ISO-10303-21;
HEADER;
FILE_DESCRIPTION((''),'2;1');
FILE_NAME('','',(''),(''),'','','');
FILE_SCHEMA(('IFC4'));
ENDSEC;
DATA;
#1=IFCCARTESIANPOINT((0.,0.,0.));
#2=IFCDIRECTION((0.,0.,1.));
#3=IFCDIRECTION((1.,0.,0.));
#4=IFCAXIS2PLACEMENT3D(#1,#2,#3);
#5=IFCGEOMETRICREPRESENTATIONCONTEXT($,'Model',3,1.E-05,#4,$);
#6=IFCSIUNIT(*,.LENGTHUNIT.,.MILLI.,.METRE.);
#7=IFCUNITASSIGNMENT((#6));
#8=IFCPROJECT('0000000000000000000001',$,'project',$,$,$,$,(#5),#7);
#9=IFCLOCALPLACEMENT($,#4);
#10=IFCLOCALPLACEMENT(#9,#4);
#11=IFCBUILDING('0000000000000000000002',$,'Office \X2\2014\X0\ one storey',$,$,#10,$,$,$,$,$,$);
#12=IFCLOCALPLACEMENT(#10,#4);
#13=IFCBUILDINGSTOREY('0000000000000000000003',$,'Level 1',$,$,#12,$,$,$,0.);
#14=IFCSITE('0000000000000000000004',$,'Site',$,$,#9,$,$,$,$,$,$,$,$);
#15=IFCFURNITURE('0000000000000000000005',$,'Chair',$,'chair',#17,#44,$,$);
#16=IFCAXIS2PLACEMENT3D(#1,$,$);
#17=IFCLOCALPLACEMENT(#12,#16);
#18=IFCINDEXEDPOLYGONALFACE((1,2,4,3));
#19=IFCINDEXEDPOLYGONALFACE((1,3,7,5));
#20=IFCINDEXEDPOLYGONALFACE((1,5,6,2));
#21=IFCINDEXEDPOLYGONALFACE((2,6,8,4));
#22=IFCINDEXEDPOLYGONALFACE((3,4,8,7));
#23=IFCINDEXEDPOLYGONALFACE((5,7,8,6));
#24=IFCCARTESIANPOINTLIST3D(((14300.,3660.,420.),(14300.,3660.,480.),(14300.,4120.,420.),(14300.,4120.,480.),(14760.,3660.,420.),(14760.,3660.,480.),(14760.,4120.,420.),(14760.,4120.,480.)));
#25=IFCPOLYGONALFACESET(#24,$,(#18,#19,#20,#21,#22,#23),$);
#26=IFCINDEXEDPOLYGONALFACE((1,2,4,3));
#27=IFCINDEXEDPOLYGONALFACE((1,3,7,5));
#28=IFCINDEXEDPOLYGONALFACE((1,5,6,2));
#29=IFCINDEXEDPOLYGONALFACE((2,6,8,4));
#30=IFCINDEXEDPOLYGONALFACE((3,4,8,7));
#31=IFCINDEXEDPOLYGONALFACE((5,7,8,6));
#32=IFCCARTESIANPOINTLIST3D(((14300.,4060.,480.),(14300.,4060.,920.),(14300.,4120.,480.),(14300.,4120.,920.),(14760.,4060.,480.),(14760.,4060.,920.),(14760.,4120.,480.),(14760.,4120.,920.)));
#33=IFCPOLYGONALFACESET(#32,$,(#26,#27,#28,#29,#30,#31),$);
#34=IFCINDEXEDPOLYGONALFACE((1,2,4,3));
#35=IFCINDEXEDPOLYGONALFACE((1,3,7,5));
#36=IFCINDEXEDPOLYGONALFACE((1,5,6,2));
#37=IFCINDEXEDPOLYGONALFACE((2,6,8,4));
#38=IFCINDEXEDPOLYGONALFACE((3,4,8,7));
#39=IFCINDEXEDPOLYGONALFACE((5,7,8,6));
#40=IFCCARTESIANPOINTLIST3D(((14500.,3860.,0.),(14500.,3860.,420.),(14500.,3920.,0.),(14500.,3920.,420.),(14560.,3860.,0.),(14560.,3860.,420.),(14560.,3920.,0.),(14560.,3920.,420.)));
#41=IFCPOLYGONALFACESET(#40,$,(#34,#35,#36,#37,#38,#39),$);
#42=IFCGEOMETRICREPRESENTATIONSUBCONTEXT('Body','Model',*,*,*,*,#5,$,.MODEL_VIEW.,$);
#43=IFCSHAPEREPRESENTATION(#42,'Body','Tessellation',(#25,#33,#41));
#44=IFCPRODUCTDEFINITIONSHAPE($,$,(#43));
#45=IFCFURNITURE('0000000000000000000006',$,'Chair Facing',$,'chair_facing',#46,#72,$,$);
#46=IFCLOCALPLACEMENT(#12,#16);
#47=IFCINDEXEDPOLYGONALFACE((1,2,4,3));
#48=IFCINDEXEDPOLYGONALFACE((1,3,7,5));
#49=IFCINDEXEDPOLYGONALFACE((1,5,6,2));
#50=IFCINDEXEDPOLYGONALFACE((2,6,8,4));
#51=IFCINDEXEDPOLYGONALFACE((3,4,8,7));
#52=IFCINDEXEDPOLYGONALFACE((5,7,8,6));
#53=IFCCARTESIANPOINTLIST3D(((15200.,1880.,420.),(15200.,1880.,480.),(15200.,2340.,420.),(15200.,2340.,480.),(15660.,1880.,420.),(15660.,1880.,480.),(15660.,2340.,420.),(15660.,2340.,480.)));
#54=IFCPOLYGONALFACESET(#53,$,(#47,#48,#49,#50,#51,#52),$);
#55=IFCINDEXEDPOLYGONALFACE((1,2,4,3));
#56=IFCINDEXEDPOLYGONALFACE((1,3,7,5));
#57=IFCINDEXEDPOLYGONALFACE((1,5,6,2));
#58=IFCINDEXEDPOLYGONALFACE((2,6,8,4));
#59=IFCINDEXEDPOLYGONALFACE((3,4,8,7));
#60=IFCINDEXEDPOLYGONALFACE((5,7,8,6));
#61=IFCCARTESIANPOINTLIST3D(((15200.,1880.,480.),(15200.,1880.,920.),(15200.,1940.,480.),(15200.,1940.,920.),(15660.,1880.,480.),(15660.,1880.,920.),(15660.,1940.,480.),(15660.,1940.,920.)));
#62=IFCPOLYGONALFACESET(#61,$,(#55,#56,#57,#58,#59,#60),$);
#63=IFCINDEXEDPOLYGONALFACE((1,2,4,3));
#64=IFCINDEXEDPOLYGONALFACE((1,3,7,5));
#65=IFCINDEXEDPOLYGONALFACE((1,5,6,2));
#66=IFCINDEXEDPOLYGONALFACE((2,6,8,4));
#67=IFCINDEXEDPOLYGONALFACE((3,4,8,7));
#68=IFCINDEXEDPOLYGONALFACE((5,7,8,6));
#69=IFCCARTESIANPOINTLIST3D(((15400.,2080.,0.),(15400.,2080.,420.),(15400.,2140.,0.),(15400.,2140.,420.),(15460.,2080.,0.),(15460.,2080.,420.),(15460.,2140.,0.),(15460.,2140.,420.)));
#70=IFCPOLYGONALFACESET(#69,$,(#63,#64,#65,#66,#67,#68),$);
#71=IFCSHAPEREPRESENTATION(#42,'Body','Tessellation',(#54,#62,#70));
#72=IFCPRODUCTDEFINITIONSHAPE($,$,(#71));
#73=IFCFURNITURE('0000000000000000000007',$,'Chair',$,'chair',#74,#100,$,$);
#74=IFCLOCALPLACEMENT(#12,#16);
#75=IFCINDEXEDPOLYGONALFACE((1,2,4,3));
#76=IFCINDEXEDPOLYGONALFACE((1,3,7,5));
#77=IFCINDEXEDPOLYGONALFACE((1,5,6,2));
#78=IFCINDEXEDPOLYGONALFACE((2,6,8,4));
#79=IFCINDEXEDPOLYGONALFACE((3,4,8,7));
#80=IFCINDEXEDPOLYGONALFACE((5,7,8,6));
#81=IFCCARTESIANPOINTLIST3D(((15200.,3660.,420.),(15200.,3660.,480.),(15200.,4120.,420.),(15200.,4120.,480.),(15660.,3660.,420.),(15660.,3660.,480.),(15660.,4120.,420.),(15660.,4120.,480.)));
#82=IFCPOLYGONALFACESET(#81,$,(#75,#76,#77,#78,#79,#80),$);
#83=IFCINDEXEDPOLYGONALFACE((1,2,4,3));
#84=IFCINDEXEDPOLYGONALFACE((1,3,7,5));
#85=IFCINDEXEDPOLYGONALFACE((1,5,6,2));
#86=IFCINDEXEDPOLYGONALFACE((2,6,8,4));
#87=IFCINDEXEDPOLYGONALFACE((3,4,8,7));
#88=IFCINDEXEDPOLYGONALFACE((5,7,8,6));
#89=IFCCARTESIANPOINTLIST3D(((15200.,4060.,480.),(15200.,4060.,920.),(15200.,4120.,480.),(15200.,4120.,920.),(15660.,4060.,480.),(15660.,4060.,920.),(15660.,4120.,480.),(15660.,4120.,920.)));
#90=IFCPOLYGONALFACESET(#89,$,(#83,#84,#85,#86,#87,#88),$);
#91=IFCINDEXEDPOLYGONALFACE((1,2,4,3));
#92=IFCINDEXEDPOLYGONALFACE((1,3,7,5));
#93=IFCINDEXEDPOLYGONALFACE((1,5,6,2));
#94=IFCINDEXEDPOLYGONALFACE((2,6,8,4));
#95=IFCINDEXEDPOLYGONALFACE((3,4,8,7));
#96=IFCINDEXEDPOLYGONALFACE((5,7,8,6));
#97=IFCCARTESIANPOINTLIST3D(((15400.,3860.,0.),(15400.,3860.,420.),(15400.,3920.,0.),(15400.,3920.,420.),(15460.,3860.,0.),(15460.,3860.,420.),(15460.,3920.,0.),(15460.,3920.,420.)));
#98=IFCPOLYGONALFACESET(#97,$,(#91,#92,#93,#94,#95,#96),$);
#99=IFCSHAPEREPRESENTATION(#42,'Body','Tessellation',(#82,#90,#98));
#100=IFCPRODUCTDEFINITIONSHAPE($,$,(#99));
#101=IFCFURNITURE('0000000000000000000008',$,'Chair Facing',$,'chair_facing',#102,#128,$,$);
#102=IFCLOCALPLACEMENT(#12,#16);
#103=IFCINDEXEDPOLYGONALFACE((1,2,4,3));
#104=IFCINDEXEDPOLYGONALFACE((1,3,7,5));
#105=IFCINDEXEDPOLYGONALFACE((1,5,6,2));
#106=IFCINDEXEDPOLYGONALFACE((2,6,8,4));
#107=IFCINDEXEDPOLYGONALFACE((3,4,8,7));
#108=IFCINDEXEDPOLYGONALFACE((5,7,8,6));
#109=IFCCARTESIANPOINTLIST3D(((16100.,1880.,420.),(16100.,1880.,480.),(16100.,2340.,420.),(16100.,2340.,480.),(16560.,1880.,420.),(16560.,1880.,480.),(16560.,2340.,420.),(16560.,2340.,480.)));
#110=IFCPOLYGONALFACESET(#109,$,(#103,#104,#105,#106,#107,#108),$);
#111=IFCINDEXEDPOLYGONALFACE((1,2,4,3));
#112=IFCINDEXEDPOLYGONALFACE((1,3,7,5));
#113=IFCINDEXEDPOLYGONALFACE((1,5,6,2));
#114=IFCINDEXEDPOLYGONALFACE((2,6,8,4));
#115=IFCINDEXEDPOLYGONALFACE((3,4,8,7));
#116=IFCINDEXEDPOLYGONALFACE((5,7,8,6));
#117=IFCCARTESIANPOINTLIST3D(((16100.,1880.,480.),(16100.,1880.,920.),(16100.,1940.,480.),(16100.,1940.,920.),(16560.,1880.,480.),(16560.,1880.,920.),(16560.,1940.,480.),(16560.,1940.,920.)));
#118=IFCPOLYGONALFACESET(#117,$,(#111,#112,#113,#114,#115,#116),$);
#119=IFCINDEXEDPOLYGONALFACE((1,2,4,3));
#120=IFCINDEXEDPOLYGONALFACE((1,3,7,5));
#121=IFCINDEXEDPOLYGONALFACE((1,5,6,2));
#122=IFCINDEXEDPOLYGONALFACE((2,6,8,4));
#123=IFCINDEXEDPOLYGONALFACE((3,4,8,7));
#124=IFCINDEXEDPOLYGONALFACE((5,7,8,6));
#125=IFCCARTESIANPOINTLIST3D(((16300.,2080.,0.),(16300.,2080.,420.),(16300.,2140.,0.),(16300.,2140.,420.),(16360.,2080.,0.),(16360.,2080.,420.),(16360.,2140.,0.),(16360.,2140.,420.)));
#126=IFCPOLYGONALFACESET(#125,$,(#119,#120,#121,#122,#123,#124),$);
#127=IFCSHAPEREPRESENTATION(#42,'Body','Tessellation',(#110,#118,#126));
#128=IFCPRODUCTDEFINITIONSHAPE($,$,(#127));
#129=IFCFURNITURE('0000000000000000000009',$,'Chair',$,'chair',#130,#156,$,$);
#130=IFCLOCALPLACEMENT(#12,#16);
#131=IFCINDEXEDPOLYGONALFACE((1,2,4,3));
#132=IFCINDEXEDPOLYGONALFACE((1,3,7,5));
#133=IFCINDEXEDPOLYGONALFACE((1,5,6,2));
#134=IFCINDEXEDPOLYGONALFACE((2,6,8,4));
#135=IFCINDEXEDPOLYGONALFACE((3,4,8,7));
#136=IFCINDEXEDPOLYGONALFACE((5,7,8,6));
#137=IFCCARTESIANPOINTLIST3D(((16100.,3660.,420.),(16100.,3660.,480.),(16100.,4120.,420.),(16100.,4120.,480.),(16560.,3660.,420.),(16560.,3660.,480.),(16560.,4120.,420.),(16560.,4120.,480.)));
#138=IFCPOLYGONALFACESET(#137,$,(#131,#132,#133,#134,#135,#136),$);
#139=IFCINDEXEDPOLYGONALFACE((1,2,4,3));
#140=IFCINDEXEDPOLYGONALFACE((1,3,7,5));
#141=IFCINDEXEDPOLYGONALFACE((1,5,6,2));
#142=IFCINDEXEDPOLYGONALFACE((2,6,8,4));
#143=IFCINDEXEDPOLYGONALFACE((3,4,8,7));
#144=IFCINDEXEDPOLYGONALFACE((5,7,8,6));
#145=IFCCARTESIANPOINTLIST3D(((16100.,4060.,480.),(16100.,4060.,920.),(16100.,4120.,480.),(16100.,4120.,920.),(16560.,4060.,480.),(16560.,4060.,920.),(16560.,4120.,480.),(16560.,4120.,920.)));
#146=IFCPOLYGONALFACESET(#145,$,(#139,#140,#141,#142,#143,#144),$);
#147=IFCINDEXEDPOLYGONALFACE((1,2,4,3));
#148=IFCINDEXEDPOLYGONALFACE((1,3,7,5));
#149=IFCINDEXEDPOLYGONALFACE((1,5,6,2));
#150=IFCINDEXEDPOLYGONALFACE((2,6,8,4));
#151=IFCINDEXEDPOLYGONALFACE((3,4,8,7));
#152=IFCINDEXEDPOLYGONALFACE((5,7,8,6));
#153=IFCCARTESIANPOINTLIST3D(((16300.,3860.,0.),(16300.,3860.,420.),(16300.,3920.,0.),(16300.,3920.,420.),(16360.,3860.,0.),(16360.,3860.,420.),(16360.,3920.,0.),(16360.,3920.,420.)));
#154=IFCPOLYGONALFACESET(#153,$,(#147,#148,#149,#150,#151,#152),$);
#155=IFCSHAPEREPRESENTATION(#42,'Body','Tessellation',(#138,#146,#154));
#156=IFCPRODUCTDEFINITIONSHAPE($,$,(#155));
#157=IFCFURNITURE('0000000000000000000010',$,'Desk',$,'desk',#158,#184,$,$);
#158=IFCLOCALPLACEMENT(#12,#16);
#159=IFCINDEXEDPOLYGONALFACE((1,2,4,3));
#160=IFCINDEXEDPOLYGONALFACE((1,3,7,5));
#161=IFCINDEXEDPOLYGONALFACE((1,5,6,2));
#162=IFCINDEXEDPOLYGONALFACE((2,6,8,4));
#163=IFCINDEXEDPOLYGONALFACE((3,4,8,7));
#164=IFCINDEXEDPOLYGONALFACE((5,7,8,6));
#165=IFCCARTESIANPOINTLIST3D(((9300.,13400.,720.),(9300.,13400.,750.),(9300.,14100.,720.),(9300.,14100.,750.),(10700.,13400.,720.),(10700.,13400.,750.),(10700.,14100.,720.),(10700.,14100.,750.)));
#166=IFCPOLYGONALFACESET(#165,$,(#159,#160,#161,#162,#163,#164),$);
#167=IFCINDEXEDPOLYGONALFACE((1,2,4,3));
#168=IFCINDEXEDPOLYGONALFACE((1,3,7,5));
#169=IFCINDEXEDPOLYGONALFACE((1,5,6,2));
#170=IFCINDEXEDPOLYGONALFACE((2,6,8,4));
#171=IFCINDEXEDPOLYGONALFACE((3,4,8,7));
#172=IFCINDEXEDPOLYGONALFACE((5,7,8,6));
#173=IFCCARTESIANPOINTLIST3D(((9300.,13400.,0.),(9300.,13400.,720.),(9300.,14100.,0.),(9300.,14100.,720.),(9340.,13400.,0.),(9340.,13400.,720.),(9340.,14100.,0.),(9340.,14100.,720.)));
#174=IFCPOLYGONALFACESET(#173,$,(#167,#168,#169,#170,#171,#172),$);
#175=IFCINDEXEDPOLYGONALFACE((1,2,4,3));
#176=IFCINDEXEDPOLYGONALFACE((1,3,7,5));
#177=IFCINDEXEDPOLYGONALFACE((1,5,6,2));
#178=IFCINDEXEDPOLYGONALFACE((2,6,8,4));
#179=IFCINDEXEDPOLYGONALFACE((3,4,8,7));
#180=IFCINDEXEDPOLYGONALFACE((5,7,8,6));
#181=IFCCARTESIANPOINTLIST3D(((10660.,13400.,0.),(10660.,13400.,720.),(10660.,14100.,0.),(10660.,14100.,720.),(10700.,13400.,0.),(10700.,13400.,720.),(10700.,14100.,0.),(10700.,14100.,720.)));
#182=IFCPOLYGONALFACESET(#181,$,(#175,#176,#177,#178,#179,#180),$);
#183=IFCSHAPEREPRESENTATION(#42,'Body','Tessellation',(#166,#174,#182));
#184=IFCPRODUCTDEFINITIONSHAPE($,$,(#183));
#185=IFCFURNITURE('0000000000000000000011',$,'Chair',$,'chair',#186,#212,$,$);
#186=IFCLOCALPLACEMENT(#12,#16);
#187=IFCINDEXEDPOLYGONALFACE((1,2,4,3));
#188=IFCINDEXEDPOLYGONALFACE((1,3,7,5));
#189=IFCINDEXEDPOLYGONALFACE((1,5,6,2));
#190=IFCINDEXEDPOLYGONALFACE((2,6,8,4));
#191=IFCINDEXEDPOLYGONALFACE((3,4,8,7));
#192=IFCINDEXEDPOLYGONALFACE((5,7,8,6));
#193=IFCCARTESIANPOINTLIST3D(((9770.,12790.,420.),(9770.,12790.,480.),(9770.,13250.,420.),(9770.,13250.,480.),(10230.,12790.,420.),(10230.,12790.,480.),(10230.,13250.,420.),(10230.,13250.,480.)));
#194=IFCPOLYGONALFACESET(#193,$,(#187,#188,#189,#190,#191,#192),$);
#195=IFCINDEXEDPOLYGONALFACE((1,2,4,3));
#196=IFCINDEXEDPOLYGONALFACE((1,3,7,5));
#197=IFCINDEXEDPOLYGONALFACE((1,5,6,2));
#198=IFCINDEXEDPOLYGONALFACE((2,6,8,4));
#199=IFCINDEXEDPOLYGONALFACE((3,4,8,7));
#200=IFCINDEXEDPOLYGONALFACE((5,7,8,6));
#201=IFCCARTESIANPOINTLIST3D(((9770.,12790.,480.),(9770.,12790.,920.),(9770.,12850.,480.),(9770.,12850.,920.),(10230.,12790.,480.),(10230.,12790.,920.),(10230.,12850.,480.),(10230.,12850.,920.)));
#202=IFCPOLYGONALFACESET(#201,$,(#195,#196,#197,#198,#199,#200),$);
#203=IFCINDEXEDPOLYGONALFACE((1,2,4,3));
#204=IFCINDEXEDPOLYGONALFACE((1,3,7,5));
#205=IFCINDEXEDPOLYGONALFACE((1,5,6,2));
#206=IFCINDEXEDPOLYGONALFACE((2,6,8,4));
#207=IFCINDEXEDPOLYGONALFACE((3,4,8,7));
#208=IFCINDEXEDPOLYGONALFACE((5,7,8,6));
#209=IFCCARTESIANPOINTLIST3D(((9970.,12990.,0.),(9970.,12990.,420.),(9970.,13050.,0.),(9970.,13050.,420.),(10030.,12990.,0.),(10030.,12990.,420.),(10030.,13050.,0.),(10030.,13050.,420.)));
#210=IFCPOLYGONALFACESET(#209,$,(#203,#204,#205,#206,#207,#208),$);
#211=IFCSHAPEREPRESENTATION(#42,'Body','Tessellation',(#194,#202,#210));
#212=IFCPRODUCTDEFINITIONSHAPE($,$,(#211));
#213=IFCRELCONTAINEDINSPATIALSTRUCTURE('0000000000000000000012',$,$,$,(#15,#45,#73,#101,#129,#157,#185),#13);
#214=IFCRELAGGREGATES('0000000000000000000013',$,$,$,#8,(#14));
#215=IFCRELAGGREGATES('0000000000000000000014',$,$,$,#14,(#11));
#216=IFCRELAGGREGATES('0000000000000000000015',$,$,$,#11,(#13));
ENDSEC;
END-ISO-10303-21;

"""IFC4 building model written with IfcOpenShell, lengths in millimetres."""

from ifc_helpers import new_model, si_unit, frame, frame_2d, origin, origin_with_axes, place, context, subcontext, project, spatial, rectangle, extrude, element, save


model = new_model("IFC4")

# Units and contexts
model_context = context("Model", 3, precision=1e-05, world=origin_with_axes())
body_context = subcontext(model_context, "Body", "Model", "MODEL_VIEW")
ifc_project = project(units=[si_unit("LENGTHUNIT", "METRE", prefix="MILLI")], contexts=[model_context])

# Site, building, storey
site_placement = place(None, origin_with_axes())
site = spatial("IfcSite", under=ifc_project, at=site_placement, Name="Site")
building_placement = place(site_placement, origin_with_axes())
building = spatial("IfcBuilding", under=site, at=building_placement, Name="Office — one storey")
storey_placement = place(building_placement, origin_with_axes())
storey = spatial("IfcBuildingStorey", under=building, at=storey_placement, Name="Level 1", Elevation=0.0)

# Furniture
furniture_1_placement = place(storey_placement, frame((14300.0, 3660.0, 0.0), z_axis=(0.0, 0.0, 1.0), x_axis=(1.0, 0.0, 0.0)))
element("IfcFurniture", 1, at=furniture_1_placement, inside=storey, Name="Chair", ObjectType="chair", context=body_context, shape_type="SweptSolid", body=[
    extrude(rectangle(XDim=460.0, YDim=460.0, at=frame_2d((230.0, 230.0))), frame((0.0, 0.0, 420.0)), (0.0, 0.0, 1.0), 60.0),
    extrude(rectangle(XDim=460.0, YDim=60.0, at=frame_2d((230.0, 430.0))), frame((0.0, 0.0, 480.0)), (0.0, 0.0, 1.0), 440.0),
    extrude(rectangle(XDim=60.0, YDim=60.0, at=frame_2d((230.0, 230.0))), origin(), (0.0, 0.0, 1.0), 420.0),
])
furniture_2_placement = place(storey_placement, frame((15200.0, 1880.0, 0.0), z_axis=(0.0, 0.0, 1.0), x_axis=(1.0, 0.0, 0.0)))
element("IfcFurniture", 2, at=furniture_2_placement, inside=storey, Name="Chair Facing", ObjectType="chair_facing", context=body_context, shape_type="SweptSolid", body=[
    extrude(rectangle(XDim=460.0, YDim=460.0, at=frame_2d((230.0, 230.0))), frame((0.0, 0.0, 420.0)), (0.0, 0.0, 1.0), 60.0),
    extrude(rectangle(XDim=460.0, YDim=60.0, at=frame_2d((230.0, 30.0))), frame((0.0, 0.0, 480.0)), (0.0, 0.0, 1.0), 440.0),
    extrude(rectangle(XDim=60.0, YDim=60.0, at=frame_2d((230.0, 230.0))), origin(), (0.0, 0.0, 1.0), 420.0),
])
furniture_3_placement = place(storey_placement, frame((15200.0, 3660.0, 0.0), z_axis=(0.0, 0.0, 1.0), x_axis=(1.0, 0.0, 0.0)))
element("IfcFurniture", 3, at=furniture_3_placement, inside=storey, Name="Chair", ObjectType="chair", context=body_context, shape_type="SweptSolid", body=[
    extrude(rectangle(XDim=460.0, YDim=460.0, at=frame_2d((230.0, 230.0))), frame((0.0, 0.0, 420.0)), (0.0, 0.0, 1.0), 60.0),
    extrude(rectangle(XDim=460.0, YDim=60.0, at=frame_2d((230.0, 430.0))), frame((0.0, 0.0, 480.0)), (0.0, 0.0, 1.0), 440.0),
    extrude(rectangle(XDim=60.0, YDim=60.0, at=frame_2d((230.0, 230.0))), origin(), (0.0, 0.0, 1.0), 420.0),
])
furniture_4_placement = place(storey_placement, frame((16100.0, 1880.0, 0.0), z_axis=(0.0, 0.0, 1.0), x_axis=(1.0, 0.0, 0.0)))
element("IfcFurniture", 4, at=furniture_4_placement, inside=storey, Name="Chair Facing", ObjectType="chair_facing", context=body_context, shape_type="SweptSolid", body=[
    extrude(rectangle(XDim=460.0, YDim=460.0, at=frame_2d((230.0, 230.0))), frame((0.0, 0.0, 420.0)), (0.0, 0.0, 1.0), 60.0),
    extrude(rectangle(XDim=460.0, YDim=60.0, at=frame_2d((230.0, 30.0))), frame((0.0, 0.0, 480.0)), (0.0, 0.0, 1.0), 440.0),
    extrude(rectangle(XDim=60.0, YDim=60.0, at=frame_2d((230.0, 230.0))), origin(), (0.0, 0.0, 1.0), 420.0),
])
furniture_5_placement = place(storey_placement, frame((16100.0, 3660.0, 0.0), z_axis=(0.0, 0.0, 1.0), x_axis=(1.0, 0.0, 0.0)))
element("IfcFurniture", 5, at=furniture_5_placement, inside=storey, Name="Chair", ObjectType="chair", context=body_context, shape_type="SweptSolid", body=[
    extrude(rectangle(XDim=460.0, YDim=460.0, at=frame_2d((230.0, 230.0))), frame((0.0, 0.0, 420.0)), (0.0, 0.0, 1.0), 60.0),
    extrude(rectangle(XDim=460.0, YDim=60.0, at=frame_2d((230.0, 430.0))), frame((0.0, 0.0, 480.0)), (0.0, 0.0, 1.0), 440.0),
    extrude(rectangle(XDim=60.0, YDim=60.0, at=frame_2d((230.0, 230.0))), origin(), (0.0, 0.0, 1.0), 420.0),
])
furniture_6_placement = place(storey_placement, frame((9300.0, 13400.0, 0.0), z_axis=(0.0, 0.0, 1.0), x_axis=(1.0, 0.0, 0.0)))
element("IfcFurniture", 6, at=furniture_6_placement, inside=storey, Name="Desk", ObjectType="desk", context=body_context, shape_type="SweptSolid", body=[
    extrude(rectangle(XDim=1400.0, YDim=700.0, at=frame_2d((700.0, 350.0))), frame((0.0, 0.0, 720.0)), (0.0, 0.0, 1.0), 30.0),
    extrude(rectangle(XDim=40.0, YDim=700.0, at=frame_2d((20.0, 350.0))), origin(), (0.0, 0.0, 1.0), 720.0),
    extrude(rectangle(XDim=40.0, YDim=700.0, at=frame_2d((1380.0, 350.0))), origin(), (0.0, 0.0, 1.0), 720.0),
])
furniture_7_placement = place(storey_placement, frame((9770.0, 12790.0, 0.0), z_axis=(0.0, 0.0, 1.0), x_axis=(1.0, 0.0, 0.0)))
element("IfcFurniture", 7, at=furniture_7_placement, inside=storey, Name="Chair", ObjectType="chair", context=body_context, shape_type="SweptSolid", body=[
    extrude(rectangle(XDim=460.0, YDim=460.0, at=frame_2d((230.0, 230.0))), frame((0.0, 0.0, 420.0)), (0.0, 0.0, 1.0), 60.0),
    extrude(rectangle(XDim=460.0, YDim=60.0, at=frame_2d((230.0, 30.0))), frame((0.0, 0.0, 480.0)), (0.0, 0.0, 1.0), 440.0),
    extrude(rectangle(XDim=60.0, YDim=60.0, at=frame_2d((230.0, 230.0))), origin(), (0.0, 0.0, 1.0), 420.0),
])

save(model, "model.ifc")
